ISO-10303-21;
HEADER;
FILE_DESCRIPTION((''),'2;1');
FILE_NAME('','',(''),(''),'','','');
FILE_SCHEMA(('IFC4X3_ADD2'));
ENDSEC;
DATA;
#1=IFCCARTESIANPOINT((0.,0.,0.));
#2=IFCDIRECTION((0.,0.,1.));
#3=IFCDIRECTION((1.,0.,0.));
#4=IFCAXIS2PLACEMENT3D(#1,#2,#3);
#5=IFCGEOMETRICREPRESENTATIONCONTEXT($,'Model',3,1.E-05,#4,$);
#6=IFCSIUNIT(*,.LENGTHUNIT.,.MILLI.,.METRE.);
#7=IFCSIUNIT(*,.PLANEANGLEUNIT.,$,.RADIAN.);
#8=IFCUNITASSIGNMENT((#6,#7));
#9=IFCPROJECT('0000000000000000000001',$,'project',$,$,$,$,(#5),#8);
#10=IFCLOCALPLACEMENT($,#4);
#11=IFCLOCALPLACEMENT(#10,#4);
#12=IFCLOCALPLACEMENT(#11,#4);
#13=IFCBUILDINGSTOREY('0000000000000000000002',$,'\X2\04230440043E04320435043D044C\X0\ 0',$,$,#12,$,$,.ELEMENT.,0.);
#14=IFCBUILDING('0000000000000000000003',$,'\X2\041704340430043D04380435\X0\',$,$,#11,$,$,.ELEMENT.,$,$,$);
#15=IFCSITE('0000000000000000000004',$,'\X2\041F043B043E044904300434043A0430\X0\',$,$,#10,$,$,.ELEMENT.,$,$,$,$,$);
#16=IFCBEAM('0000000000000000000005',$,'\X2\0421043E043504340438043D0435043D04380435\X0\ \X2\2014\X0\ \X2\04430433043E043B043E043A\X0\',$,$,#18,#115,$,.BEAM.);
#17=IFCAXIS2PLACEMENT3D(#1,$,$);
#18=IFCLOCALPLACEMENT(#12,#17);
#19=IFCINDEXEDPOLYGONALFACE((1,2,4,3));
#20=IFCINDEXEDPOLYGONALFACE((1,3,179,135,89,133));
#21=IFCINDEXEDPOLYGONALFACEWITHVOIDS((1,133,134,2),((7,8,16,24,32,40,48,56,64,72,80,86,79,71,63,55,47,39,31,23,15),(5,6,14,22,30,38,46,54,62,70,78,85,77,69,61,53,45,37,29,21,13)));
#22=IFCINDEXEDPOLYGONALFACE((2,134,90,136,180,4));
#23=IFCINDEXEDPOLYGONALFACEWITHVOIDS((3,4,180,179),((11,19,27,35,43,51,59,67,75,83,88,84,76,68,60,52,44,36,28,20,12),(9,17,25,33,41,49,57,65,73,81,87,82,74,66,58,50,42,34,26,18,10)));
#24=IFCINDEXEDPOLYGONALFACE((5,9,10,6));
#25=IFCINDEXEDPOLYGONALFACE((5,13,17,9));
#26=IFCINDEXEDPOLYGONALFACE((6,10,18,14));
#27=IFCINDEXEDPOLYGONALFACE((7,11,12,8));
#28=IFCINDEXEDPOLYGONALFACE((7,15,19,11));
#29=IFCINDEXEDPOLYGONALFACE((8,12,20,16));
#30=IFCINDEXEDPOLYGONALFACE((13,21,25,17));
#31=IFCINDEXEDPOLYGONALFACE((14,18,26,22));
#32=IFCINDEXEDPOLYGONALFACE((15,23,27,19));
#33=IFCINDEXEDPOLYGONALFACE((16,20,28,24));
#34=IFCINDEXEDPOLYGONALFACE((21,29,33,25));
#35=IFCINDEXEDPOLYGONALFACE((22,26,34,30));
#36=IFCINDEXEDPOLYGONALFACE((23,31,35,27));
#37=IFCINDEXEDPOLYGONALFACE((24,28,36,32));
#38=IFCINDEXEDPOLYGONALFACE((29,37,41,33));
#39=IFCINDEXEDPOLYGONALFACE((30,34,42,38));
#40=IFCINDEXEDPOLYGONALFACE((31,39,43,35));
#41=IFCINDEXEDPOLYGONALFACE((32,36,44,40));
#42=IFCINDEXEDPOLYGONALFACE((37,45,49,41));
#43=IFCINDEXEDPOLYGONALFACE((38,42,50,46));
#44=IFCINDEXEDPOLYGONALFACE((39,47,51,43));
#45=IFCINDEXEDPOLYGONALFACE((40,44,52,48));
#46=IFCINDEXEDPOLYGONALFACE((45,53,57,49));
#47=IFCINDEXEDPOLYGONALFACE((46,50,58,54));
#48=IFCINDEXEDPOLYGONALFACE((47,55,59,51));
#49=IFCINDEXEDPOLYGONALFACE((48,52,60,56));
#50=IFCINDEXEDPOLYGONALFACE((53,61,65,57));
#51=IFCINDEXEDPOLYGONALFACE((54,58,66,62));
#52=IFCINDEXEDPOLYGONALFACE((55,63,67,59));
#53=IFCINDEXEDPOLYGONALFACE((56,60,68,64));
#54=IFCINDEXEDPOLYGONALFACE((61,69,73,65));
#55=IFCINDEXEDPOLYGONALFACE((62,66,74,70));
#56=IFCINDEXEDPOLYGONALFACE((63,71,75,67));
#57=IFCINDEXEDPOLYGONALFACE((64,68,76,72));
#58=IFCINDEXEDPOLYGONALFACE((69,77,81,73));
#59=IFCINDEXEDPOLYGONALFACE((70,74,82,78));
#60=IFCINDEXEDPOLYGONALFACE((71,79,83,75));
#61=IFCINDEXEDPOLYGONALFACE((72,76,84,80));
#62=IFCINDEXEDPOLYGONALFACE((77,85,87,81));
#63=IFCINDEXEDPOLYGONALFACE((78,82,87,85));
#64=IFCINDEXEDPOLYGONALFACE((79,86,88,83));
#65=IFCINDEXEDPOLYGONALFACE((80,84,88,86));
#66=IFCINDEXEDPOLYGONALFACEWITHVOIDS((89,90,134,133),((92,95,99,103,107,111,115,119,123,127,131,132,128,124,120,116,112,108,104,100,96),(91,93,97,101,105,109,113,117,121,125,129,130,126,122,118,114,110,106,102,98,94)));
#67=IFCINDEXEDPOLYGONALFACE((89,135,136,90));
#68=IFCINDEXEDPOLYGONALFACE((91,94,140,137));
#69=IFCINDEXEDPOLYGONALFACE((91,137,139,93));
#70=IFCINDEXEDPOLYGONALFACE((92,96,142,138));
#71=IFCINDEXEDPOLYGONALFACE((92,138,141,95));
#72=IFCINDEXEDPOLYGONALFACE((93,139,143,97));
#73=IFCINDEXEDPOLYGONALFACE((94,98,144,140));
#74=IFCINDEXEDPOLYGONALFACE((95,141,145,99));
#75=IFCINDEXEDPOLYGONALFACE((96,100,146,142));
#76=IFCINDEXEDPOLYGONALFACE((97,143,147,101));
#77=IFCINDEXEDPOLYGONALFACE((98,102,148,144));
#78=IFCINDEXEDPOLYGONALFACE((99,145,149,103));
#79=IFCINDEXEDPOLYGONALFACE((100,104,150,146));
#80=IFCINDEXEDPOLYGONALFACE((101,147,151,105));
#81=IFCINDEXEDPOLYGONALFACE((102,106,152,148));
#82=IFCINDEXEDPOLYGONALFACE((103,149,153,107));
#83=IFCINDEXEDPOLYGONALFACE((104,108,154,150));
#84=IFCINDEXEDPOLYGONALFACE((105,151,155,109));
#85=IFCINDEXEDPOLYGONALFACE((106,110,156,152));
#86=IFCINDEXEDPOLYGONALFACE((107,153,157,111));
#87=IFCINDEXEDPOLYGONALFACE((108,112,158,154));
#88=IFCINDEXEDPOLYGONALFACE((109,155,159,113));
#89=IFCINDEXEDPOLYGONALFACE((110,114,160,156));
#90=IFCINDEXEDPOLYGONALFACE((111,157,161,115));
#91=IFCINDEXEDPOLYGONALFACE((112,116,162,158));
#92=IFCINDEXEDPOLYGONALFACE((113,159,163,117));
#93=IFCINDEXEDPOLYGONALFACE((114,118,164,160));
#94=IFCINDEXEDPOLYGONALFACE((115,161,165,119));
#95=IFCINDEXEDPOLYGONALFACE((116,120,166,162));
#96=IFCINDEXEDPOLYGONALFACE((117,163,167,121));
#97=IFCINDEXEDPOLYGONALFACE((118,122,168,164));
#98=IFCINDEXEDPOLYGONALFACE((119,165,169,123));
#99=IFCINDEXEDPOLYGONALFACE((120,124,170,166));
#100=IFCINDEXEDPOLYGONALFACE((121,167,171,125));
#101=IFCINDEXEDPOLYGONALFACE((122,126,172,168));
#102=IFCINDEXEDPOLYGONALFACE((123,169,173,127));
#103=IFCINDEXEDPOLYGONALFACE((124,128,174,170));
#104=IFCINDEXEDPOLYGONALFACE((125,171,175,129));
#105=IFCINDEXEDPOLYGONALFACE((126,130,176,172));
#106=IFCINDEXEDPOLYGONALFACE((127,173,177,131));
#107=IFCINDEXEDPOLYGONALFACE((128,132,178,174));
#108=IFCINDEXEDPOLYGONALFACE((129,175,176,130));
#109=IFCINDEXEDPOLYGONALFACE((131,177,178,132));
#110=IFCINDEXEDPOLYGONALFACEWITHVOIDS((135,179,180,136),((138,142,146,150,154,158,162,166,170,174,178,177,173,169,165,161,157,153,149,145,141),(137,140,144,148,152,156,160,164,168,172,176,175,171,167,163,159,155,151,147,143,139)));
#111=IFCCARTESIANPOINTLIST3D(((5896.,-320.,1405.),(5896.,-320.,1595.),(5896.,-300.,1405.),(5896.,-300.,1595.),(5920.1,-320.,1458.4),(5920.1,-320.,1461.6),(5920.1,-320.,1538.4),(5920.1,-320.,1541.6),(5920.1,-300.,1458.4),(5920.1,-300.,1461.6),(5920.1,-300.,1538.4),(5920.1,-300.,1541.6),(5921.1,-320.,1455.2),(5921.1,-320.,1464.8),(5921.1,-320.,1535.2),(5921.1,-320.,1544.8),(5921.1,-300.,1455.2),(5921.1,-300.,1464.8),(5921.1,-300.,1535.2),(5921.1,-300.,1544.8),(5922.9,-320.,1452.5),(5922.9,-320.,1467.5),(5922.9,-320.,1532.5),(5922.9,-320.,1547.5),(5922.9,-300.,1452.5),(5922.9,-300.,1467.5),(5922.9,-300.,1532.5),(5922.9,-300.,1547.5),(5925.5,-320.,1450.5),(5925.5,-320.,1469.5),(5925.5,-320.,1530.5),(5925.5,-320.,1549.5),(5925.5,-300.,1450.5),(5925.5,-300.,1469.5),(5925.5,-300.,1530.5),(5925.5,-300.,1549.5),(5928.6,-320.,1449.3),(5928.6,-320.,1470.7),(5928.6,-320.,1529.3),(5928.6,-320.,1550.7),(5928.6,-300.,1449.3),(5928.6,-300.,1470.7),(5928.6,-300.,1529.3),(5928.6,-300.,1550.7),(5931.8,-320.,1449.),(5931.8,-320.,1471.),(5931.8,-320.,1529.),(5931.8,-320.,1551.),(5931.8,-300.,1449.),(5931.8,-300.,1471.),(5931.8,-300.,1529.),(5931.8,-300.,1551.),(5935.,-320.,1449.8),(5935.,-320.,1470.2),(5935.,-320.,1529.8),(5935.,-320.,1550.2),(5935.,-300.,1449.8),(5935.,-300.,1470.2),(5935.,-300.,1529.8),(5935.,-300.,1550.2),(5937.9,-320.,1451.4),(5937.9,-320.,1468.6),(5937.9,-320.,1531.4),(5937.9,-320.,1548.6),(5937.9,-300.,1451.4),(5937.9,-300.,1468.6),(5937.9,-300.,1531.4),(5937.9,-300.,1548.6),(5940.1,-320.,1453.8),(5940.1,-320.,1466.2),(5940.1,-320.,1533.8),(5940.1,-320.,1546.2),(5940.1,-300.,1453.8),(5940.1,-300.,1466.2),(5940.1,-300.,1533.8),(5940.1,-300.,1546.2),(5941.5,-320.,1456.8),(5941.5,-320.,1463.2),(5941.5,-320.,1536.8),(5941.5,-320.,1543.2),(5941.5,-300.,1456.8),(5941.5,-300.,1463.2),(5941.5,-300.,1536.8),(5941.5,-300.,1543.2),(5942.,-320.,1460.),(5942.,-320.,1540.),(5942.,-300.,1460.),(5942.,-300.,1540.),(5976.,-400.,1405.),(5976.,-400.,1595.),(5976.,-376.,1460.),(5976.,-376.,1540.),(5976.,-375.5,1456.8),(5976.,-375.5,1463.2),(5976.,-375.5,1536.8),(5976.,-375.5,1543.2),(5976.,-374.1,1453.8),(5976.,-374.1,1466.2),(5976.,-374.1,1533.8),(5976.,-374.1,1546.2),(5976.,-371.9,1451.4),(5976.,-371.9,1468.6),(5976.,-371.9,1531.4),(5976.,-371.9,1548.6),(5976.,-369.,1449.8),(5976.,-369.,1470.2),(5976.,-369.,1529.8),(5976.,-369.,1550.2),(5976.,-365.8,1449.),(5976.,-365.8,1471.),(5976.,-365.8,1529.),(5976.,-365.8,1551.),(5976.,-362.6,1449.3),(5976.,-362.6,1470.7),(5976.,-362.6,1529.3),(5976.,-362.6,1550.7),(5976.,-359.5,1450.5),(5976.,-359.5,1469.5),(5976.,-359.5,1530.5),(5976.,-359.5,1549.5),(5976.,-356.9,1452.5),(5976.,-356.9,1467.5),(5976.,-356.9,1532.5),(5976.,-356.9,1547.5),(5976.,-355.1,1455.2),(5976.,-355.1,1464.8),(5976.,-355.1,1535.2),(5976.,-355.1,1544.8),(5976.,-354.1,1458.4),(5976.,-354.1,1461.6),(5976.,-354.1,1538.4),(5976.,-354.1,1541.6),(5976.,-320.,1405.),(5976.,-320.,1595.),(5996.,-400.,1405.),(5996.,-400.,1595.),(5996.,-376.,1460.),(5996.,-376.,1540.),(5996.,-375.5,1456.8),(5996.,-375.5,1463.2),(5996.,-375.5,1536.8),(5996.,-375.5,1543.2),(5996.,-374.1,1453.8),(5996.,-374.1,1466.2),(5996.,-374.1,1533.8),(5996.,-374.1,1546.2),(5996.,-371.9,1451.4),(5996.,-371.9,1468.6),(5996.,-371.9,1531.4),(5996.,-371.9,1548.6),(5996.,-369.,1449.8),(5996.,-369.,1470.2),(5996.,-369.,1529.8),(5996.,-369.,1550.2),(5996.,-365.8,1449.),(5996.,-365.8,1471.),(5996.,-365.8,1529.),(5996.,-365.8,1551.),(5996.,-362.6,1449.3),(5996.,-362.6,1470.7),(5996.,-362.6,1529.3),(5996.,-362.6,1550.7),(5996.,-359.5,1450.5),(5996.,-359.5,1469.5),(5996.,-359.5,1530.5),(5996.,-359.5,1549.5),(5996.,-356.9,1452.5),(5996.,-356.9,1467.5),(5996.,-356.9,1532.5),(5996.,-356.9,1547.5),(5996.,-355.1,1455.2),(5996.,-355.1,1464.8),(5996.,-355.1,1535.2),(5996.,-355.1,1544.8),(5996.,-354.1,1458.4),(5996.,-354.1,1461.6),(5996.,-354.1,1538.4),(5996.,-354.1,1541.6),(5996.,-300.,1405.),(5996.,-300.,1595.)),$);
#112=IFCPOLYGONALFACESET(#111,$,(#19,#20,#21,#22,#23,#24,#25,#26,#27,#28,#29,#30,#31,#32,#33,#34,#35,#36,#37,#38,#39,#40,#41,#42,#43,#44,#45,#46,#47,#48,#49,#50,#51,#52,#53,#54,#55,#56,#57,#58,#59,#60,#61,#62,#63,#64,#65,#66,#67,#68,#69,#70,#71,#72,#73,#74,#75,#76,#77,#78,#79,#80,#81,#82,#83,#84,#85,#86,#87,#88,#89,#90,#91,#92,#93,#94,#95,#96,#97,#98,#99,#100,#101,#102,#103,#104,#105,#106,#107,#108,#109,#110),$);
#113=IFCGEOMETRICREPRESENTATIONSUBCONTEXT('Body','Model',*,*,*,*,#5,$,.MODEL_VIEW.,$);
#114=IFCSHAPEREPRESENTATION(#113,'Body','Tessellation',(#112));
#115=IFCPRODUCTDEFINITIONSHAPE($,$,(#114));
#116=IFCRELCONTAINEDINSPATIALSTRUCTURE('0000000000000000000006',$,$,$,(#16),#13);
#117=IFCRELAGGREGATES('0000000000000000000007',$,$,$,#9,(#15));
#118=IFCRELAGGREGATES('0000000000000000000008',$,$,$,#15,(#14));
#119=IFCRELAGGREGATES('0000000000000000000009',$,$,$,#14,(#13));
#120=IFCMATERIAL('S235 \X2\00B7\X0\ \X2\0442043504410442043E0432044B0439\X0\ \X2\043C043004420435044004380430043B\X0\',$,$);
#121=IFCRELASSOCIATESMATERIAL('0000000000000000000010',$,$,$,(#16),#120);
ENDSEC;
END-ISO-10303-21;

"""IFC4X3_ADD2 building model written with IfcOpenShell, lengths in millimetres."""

from ifc_helpers import new_model, si_unit, frame, origin_with_axes, place, context, subcontext, project, spatial, circle, l_section, extrude, material, element, save


model = new_model("IFC4X3_ADD2")

# Units and contexts
model_context = context("Model", 3, precision=1e-05, world=origin_with_axes())
body_context = subcontext(model_context, "Body", "Model", "MODEL_VIEW")
ifc_project = project(units=[si_unit("LENGTHUNIT", "METRE", prefix="MILLI"), si_unit("PLANEANGLEUNIT", "RADIAN")], contexts=[model_context])

# Site, building, storey
site_placement = place(None, origin_with_axes())
site = spatial("IfcSite", under=ifc_project, at=site_placement, Name="Площадка", CompositionType="ELEMENT")
building_placement = place(site_placement, origin_with_axes())
building = spatial("IfcBuilding", under=site, at=building_placement, Name="Здание", CompositionType="ELEMENT")
storey_placement = place(building_placement, origin_with_axes())
storey = spatial("IfcBuildingStorey", under=building, at=storey_placement, Name="Уровень 0", CompositionType="ELEMENT", Elevation=0.0)

# Shared definitions
ifc_material = material(Name="S235 · тестовый материал")

# Beam, openings
beam_1_placement = place(storey_placement, frame((5946.0, -350.0, 1595.0), z_axis=(0.0, 0.0, -1.0), x_axis=(0.0, -1.0, 0.0)))
beam_1 = element("IfcBeam", 1, at=beam_1_placement, inside=storey, material=ifc_material, Name="Соединение — уголок", PredefinedType="BEAM", context=body_context, shape_type="SweptSolid", body=[
    extrude(l_section(Depth=100.0, Width=100.0, Thickness=20.0), origin_with_axes(), (0.0, 0.0, 1.0), 190.0),
])
opening_1_placement = place(beam_1_placement, frame((15.0, -29.0, 55.0), z_axis=(0.0, -1.0, 0.0), x_axis=(1.0, 0.0, 0.0)))
element("IfcOpeningElement", 2, at=opening_1_placement, cuts=beam_1, PredefinedType="OPENING", context=body_context, shape_type="SweptSolid", body=[
    extrude(circle(Radius=11.0), origin_with_axes(), (0.0, 0.0, 1.0), 30.0),
])
opening_2_placement = place(beam_1_placement, frame((15.0, -29.0, 135.0), z_axis=(0.0, -1.0, 0.0), x_axis=(1.0, 0.0, 0.0)))
element("IfcOpeningElement", 3, at=opening_2_placement, cuts=beam_1, PredefinedType="OPENING", context=body_context, shape_type="SweptSolid", body=[
    extrude(circle(Radius=11.0), origin_with_axes(), (0.0, 0.0, 1.0), 30.0),
])
opening_3_placement = place(beam_1_placement, frame((-29.0, 15.0, 55.0), z_axis=(-1.0, 0.0, 0.0), x_axis=(0.0, -1.0, 0.0)))
element("IfcOpeningElement", 4, at=opening_3_placement, cuts=beam_1, PredefinedType="OPENING", context=body_context, shape_type="SweptSolid", body=[
    extrude(circle(Radius=11.0), origin_with_axes(), (0.0, 0.0, 1.0), 42.0),
])
opening_4_placement = place(beam_1_placement, frame((-29.0, 15.0, 135.0), z_axis=(-1.0, 0.0, 0.0), x_axis=(0.0, -1.0, 0.0)))
element("IfcOpeningElement", 5, at=opening_4_placement, cuts=beam_1, PredefinedType="OPENING", context=body_context, shape_type="SweptSolid", body=[
    extrude(circle(Radius=11.0), origin_with_axes(), (0.0, 0.0, 1.0), 42.0),
])

save(model, "model.ifc")
